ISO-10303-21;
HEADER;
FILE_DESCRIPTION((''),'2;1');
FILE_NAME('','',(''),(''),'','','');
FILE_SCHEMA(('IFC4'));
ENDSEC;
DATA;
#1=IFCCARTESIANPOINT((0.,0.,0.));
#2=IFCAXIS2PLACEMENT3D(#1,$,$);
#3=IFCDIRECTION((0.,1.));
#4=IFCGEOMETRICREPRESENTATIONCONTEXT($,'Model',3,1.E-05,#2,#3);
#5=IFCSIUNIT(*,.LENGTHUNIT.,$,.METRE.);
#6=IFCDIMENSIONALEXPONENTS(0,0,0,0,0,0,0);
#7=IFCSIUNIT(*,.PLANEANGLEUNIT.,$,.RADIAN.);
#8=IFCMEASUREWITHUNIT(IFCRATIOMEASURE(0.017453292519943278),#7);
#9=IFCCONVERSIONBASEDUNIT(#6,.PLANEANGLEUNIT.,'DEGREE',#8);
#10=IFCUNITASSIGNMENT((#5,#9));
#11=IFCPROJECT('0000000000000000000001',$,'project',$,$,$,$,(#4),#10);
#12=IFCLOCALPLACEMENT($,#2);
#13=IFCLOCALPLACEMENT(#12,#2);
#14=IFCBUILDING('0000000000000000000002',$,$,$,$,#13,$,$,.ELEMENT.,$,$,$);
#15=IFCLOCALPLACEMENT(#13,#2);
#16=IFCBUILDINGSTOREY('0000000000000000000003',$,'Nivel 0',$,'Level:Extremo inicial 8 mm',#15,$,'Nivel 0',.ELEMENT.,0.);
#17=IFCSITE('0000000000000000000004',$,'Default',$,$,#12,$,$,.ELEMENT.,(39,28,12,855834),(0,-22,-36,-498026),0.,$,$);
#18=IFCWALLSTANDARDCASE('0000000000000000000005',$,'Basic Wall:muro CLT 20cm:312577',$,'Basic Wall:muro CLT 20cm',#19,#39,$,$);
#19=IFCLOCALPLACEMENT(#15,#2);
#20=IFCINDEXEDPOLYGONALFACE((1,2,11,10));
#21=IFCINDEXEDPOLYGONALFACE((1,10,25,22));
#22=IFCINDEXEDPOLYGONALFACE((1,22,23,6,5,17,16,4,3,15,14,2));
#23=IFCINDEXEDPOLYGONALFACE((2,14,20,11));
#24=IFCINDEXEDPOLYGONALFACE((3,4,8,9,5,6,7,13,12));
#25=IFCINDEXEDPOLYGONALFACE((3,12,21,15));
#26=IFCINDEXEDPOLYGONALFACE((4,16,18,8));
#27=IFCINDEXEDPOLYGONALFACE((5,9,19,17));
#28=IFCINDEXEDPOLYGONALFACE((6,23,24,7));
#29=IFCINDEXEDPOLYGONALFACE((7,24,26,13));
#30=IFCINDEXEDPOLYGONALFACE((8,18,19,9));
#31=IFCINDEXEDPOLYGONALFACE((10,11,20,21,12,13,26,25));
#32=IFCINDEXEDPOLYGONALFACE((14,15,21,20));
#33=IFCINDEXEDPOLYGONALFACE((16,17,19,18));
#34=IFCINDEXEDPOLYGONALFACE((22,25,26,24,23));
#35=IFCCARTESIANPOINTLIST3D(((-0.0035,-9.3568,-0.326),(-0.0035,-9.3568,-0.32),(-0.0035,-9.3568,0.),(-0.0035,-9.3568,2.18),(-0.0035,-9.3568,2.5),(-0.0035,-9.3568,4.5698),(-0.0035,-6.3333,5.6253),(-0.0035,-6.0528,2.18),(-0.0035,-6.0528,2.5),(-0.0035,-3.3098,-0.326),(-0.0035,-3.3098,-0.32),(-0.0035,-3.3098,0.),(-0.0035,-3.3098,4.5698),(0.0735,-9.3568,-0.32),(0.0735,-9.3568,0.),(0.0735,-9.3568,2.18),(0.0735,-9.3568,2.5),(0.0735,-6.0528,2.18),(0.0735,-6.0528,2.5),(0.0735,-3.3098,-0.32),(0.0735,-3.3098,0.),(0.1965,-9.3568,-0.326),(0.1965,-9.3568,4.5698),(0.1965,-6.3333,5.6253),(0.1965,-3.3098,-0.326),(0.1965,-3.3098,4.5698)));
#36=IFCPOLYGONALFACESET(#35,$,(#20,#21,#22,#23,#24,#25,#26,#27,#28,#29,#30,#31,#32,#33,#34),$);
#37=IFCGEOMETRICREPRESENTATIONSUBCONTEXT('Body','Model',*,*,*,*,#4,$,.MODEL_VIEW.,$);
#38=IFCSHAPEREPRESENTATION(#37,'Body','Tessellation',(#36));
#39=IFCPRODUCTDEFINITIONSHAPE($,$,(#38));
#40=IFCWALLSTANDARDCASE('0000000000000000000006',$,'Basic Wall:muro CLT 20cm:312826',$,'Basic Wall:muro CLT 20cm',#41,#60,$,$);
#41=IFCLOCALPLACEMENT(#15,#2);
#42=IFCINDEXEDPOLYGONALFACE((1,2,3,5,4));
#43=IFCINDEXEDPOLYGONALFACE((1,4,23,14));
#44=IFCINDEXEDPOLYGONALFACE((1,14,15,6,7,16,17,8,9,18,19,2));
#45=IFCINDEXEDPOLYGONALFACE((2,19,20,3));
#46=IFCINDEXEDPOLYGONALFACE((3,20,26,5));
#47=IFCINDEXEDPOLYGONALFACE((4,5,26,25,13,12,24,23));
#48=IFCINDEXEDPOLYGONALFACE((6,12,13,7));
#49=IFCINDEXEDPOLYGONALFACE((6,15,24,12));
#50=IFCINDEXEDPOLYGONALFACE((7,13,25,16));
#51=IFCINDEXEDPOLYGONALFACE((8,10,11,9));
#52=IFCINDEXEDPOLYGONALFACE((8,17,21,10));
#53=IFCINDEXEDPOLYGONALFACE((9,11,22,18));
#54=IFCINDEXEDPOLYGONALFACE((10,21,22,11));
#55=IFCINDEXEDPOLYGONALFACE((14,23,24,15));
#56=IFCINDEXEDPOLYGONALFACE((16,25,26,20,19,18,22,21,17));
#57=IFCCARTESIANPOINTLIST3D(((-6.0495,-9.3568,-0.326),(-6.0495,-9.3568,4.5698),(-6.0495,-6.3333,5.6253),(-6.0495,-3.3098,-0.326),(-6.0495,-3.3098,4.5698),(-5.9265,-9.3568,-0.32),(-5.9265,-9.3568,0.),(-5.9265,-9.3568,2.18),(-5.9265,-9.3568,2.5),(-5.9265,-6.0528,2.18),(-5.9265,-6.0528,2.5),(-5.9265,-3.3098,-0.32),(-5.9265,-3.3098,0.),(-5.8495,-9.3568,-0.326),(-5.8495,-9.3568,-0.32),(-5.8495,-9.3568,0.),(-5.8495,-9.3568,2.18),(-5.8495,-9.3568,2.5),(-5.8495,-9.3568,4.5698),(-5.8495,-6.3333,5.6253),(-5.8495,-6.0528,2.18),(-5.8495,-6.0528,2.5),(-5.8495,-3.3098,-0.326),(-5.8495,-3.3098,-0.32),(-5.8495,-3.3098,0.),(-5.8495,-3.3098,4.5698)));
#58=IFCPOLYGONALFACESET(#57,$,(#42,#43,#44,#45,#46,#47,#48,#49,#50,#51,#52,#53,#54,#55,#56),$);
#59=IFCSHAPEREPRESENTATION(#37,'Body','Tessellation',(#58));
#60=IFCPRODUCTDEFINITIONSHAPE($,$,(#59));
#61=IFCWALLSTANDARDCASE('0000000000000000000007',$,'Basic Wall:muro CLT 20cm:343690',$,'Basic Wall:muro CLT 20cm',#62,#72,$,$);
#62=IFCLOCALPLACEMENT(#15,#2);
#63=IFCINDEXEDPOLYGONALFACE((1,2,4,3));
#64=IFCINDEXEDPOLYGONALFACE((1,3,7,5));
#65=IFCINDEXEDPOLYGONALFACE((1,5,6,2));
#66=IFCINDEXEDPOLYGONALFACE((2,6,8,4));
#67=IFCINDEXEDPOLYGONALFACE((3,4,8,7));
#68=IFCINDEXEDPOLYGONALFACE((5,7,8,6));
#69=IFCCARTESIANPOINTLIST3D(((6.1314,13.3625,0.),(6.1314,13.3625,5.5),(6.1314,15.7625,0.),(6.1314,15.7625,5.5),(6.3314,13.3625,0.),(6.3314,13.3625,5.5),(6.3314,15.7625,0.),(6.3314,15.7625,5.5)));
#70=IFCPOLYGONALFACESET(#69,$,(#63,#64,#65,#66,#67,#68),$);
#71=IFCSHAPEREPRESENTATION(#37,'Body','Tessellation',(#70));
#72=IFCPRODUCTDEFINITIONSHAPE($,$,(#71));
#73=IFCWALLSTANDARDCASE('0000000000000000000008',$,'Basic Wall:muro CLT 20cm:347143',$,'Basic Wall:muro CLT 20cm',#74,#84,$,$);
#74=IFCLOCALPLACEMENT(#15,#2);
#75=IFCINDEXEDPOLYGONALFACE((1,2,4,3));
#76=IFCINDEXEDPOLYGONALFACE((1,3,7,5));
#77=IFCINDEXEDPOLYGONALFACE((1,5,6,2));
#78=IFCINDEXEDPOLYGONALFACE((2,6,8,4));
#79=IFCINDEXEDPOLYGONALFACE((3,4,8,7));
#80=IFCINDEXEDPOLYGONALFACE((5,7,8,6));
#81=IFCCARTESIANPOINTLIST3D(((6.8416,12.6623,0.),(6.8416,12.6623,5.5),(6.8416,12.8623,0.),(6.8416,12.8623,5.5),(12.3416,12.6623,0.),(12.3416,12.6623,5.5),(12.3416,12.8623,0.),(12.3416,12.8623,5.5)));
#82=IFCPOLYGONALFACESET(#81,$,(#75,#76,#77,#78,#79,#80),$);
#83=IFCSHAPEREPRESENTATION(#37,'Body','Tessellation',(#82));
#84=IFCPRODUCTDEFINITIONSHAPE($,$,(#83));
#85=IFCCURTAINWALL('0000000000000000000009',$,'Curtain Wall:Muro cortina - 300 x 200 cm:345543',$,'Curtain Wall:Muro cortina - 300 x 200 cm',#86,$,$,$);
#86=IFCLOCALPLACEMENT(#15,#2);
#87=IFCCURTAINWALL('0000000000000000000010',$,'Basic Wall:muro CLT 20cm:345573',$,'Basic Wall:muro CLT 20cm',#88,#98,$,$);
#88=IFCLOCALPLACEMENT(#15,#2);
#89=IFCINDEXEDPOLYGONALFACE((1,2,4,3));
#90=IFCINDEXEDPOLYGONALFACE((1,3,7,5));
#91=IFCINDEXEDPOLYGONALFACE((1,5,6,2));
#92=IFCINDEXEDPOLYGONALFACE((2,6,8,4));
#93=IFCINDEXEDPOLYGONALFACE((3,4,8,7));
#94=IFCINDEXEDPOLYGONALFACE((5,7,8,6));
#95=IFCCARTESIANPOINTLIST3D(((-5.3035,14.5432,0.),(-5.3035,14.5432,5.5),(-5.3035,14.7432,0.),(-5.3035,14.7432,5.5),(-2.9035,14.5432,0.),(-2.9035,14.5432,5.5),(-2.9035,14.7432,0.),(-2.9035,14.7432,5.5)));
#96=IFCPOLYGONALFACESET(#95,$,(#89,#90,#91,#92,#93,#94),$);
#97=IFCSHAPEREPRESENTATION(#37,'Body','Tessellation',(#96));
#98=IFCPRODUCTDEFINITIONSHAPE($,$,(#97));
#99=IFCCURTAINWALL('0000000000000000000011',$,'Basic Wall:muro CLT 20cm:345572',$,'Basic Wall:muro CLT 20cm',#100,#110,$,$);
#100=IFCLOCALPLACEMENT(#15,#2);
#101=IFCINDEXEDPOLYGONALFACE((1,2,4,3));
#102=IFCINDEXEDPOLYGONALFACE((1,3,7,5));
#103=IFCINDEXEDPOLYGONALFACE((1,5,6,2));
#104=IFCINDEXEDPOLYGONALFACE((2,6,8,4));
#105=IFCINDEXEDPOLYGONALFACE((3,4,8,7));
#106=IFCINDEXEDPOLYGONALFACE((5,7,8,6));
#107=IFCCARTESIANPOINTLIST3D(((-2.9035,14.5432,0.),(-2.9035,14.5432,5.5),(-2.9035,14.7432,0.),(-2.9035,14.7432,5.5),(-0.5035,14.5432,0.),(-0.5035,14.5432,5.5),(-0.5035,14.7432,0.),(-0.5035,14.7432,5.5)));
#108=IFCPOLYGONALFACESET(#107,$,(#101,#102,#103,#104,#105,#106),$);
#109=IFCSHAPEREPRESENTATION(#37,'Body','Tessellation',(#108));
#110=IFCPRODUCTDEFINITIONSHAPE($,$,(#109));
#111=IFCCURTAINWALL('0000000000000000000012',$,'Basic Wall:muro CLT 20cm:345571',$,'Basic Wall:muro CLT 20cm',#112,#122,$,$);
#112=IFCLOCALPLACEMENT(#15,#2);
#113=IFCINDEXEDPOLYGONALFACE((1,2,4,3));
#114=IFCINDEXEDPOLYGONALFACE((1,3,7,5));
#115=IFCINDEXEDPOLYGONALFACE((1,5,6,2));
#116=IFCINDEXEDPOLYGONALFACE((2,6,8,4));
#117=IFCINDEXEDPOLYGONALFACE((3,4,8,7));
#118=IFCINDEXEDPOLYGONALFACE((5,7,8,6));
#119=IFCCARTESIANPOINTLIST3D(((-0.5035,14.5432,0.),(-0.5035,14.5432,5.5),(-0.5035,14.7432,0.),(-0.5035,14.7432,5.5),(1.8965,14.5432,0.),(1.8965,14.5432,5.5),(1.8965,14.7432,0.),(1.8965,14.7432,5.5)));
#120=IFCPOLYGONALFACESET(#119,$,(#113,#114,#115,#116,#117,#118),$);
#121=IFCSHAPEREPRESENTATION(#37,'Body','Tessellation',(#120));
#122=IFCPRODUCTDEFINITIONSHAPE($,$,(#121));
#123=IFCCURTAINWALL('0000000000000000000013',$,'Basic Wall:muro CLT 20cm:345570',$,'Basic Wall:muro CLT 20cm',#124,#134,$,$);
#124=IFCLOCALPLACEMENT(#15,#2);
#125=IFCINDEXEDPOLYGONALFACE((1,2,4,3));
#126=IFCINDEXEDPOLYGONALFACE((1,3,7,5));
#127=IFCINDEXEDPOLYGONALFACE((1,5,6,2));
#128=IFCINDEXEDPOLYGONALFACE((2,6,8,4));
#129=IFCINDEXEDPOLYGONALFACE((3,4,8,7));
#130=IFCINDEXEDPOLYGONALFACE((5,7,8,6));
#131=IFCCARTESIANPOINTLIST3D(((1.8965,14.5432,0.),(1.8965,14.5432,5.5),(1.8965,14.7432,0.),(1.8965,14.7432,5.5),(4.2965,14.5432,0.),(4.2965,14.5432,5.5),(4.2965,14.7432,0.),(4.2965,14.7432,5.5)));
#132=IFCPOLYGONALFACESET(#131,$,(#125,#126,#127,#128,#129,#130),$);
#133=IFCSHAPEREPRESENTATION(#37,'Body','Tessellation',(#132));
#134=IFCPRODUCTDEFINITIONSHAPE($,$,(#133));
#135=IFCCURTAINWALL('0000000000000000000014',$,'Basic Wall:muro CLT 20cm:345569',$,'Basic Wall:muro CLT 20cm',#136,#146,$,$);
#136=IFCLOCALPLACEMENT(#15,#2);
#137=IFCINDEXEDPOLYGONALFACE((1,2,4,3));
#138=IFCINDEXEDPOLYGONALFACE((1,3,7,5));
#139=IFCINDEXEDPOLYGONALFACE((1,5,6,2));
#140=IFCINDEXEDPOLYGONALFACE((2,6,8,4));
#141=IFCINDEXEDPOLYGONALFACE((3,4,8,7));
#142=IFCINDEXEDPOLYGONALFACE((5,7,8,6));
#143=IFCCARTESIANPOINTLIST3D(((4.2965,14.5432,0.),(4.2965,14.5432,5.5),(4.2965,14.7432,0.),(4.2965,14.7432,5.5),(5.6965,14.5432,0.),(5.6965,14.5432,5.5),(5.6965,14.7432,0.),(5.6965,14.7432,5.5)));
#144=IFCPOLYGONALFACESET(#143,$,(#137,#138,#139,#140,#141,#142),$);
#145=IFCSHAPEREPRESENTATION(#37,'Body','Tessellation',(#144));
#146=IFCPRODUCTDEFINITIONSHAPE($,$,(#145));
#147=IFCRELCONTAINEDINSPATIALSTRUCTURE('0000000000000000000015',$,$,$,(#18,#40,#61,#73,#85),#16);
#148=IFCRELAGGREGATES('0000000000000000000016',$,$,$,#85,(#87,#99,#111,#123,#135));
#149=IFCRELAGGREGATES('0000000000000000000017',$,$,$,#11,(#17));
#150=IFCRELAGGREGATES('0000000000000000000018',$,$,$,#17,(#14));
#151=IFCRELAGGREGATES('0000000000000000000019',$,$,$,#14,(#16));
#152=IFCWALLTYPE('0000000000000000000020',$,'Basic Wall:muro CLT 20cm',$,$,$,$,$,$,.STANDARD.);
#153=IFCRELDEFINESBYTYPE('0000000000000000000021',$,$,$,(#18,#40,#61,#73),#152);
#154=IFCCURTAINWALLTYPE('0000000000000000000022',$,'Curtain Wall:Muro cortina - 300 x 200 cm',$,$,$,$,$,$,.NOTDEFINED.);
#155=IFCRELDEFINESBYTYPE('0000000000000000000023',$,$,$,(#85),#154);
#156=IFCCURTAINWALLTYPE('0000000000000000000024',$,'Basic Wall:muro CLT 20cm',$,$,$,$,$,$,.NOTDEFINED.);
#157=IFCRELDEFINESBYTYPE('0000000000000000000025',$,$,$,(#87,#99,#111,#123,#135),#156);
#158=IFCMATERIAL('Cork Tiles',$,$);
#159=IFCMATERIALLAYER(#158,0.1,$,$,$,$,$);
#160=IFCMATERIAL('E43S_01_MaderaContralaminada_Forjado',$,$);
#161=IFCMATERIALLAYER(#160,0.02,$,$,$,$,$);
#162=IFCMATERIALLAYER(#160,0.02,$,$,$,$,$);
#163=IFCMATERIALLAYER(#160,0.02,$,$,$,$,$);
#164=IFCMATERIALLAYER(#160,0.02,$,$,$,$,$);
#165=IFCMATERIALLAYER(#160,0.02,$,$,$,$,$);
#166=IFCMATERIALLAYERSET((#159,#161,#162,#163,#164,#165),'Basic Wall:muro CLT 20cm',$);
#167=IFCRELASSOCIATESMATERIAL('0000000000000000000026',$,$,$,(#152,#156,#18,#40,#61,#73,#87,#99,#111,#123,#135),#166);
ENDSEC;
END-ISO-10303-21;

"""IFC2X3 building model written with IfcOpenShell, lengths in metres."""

from ifc_helpers import new_model, entity, si_unit, converted_unit, direction, frame, frame_2d, origin, place, context, subcontext, project, spatial, polyline, rectangle, extrude, clip, bounded_halfspace, material, layer, layer_set, layer_usage, type_object, element, aggregate, save


model = new_model("IFC2X3")

# Units and contexts
model_context = context("Model", 3, precision=1e-05, world=origin(), true_north=direction((0.0, 1.0)))
body_context = subcontext(model_context, "Body", "Model", "MODEL_VIEW")
ifc_project = project(units=[si_unit("LENGTHUNIT", "METRE"), converted_unit("PLANEANGLEUNIT", "DEGREE", entity("IfcRatioMeasure", 0.017453292519943278), si_unit("PLANEANGLEUNIT", "RADIAN"), dimensions=[0, 0, 0, 0, 0, 0, 0])], contexts=[model_context])

# Site, building, storey
site_placement = place(None, origin())
site = spatial("IfcSite", under=ifc_project, at=site_placement, Name="Default", CompositionType="ELEMENT", RefLatitude=(39, 28, 12, 855834), RefLongitude=(0, -22, -36, -498026), RefElevation=0.0)
building_placement = place(site_placement, origin())
building = spatial("IfcBuilding", under=site, at=building_placement, CompositionType="ELEMENT")
storey_placement = place(building_placement, origin())
storey = spatial("IfcBuildingStorey", under=building, at=storey_placement, Name="Nivel 0", ObjectType="Level:Extremo inicial 8 mm", LongName="Nivel 0", CompositionType="ELEMENT", Elevation=0.0)

# Shared definitions
ifc_material_1 = material(Name="E43S_01_MaderaContralaminada_Forjado")
ifc_material_2 = material(Name="Cork Tiles")

# Shared definitions
ifc_layer_1 = layer(ifc_material_2, 0.1)
ifc_layer_2 = layer(ifc_material_1, 0.02)
ifc_layer_3 = layer(ifc_material_1, 0.02)
ifc_layer_4 = layer(ifc_material_1, 0.02)
ifc_layer_5 = layer(ifc_material_1, 0.02)
ifc_layer_6 = layer(ifc_material_1, 0.02)
ifc_layer_set_1 = layer_set([ifc_layer_1, ifc_layer_2, ifc_layer_3, ifc_layer_4, ifc_layer_5, ifc_layer_6], Name="Basic Wall:muro CLT 20cm")
wall_type = type_object("IfcWallType", Name="Basic Wall:muro CLT 20cm", PredefinedType="STANDARD", material=ifc_layer_set_1)

# Walls, openings
ifc_layer_usage_1 = layer_usage(ifc_layer_set_1, "AXIS2", "NEGATIVE", 0.1)
wall_1_placement = place(storey_placement, frame((0.0965, -3.3098, -0.326), z_axis=(0.0, 0.0, 1.0), x_axis=(0.0, -1.0, 0.0)))
wall_1 = element("IfcWallStandardCase", 1, at=wall_1_placement, inside=storey, type_object=wall_type, material=ifc_layer_usage_1, Name="Basic Wall:muro CLT 20cm:312577", ObjectType="Basic Wall:muro CLT 20cm", context=body_context, shape_type="Clipping", body=[
    clip(clip(clip(extrude(rectangle(XDim=6.047, YDim=0.2, at=frame_2d((3.0235, 0.0), x_axis=(-1.0, 0.0))), origin(), (0.0, 0.0, 1.0), 5.9513), bounded_halfspace(frame((0.0, 0.1, 4.8958), z_axis=(-0.329578, 0.0, 0.944128), x_axis=(0.0, -1.0, 0.0)), False, frame((0.0, 0.1, 4.8958)), polyline([(0.0, 0.0), (0.0, -0.2), (3.0235, -0.2), (3.0235, 0.0), (0.0, 0.0)]))), bounded_halfspace(frame((3.0235, -0.1, 5.9513), z_axis=(0.329578, 0.0, 0.944128), x_axis=(0.0, 1.0, 0.0)), False, frame((3.0235, -0.1, 5.9513)), polyline([(0.0, 0.0), (3.0235, 0.0), (3.0235, 0.2), (0.0, 0.2), (0.0, 0.0)]))), bounded_halfspace(frame((6.047, -0.023, 0.006), z_axis=(0.0, 1.0, 0.0), x_axis=(0.0, 0.0, 1.0)), True, frame((6.047, -0.023, 0.006), z_axis=(0.0, 1.0, 0.0), x_axis=(0.0, 0.0, 1.0)), polyline([(0.0, 0.0), (0.0, -6.047), (0.32, -6.047), (0.32, 0.0), (0.0, 0.0)]))),
])
opening_1_placement = place(storey_placement, frame((0.0965, -3.3098, -0.326), z_axis=(0.0, 0.0, 1.0), x_axis=(0.0, -1.0, 0.0)))
element("IfcOpeningElement", 2, at=opening_1_placement, cuts=wall_1, ObjectType="Opening", context=body_context, shape_type="SweptSolid", body=[
    extrude(rectangle(XDim=0.077, YDim=3.304, at=frame_2d((0.0, 0.0), x_axis=(1.0, 0.0))), frame((4.395, -0.0615, 2.506), z_axis=(0.0, 0.0, 1.0), x_axis=(0.0, -1.0, 0.0)), (0.0, 0.0, 1.0), 0.32),
])
ifc_layer_usage_2 = layer_usage(ifc_layer_set_1, "AXIS2", "NEGATIVE", 0.1)
wall_2_placement = place(storey_placement, frame((-5.9495, -9.3568, -0.326), z_axis=(0.0, 0.0, 1.0), x_axis=(0.0, 1.0, 0.0)))
wall_2 = element("IfcWallStandardCase", 3, at=wall_2_placement, inside=storey, type_object=wall_type, material=ifc_layer_usage_2, Name="Basic Wall:muro CLT 20cm:312826", ObjectType="Basic Wall:muro CLT 20cm", context=body_context, shape_type="Clipping", body=[
    clip(clip(clip(extrude(rectangle(XDim=6.047, YDim=0.2, at=frame_2d((3.0235, 0.0), x_axis=(-1.0, 0.0))), origin(), (0.0, 0.0, 1.0), 5.9513), bounded_halfspace(frame((6.047, -0.1, 4.8958), z_axis=(0.329578, 0.0, 0.944128), x_axis=(0.0, 1.0, 0.0)), False, frame((6.047, -0.1, 4.8958)), polyline([(0.0, 0.0), (0.0, 0.2), (-3.0235, 0.2), (-3.0235, 0.0), (0.0, 0.0)]))), bounded_halfspace(frame((0.0, 0.1, 4.8958), z_axis=(-0.329578, 0.0, 0.944128), x_axis=(0.0, -1.0, 0.0)), False, frame((0.0, 0.1, 4.8958)), polyline([(0.0, 0.0), (0.0, -0.2), (3.0235, -0.2), (3.0235, 0.0), (0.0, 0.0)]))), bounded_halfspace(frame((0.0, -0.023, 0.006), z_axis=(0.0, 1.0, 0.0), x_axis=(0.0, 0.0, 1.0)), True, frame((0.0, -0.023, 0.006), z_axis=(0.0, 1.0, 0.0), x_axis=(0.0, 0.0, 1.0)), polyline([(0.0, 0.0), (0.32, 0.0), (0.32, 6.047), (0.0, 6.047), (0.0, 0.0)]))),
])
opening_2_placement = place(storey_placement, frame((-5.9495, -9.3568, -0.326), z_axis=(0.0, 0.0, 1.0), x_axis=(0.0, 1.0, 0.0)))
element("IfcOpeningElement", 4, at=opening_2_placement, cuts=wall_2, ObjectType="Opening", context=body_context, shape_type="SweptSolid", body=[
    extrude(rectangle(XDim=0.077, YDim=3.304, at=frame_2d((0.0, 0.0), x_axis=(1.0, 0.0))), frame((1.652, -0.0615, 2.506), z_axis=(0.0, 0.0, 1.0), x_axis=(0.0, 1.0, 0.0)), (0.0, 0.0, 1.0), 0.32),
])

# Walls
ifc_layer_usage_3 = layer_usage(ifc_layer_set_1, "AXIS2", "NEGATIVE", 0.1)
wall_3_placement = place(storey_placement, frame((6.2314, 13.3625, 0.0), z_axis=(0.0, 0.0, 1.0), x_axis=(0.0, 1.0, 0.0)))
element("IfcWallStandardCase", 5, at=wall_3_placement, inside=storey, type_object=wall_type, material=ifc_layer_usage_3, Name="Basic Wall:muro CLT 20cm:343690", ObjectType="Basic Wall:muro CLT 20cm", context=body_context, shape_type="SweptSolid", body=[
    extrude(rectangle(XDim=2.4, YDim=0.2, at=frame_2d((1.2, 0.0), x_axis=(-1.0, 0.0))), origin(), (0.0, 0.0, 1.0), 5.5),
])
ifc_layer_usage_4 = layer_usage(ifc_layer_set_1, "AXIS2", "POSITIVE", -0.1)
wall_4_placement = place(storey_placement, frame((6.8416, 12.7623, 0.0)))
element("IfcWallStandardCase", 6, at=wall_4_placement, inside=storey, type_object=wall_type, material=ifc_layer_usage_4, Name="Basic Wall:muro CLT 20cm:347143", ObjectType="Basic Wall:muro CLT 20cm", context=body_context, shape_type="SweptSolid", body=[
    extrude(rectangle(XDim=5.5, YDim=0.2, at=frame_2d((2.75, 0.0), x_axis=(-1.0, 0.0))), origin(), (0.0, 0.0, 1.0), 5.5),
])

# Curtain walls
curtain_wall_type_1 = type_object("IfcCurtainWallType", Name="Curtain Wall:Muro cortina - 300 x 200 cm", PredefinedType="NOTDEFINED")
curtain_wall_1_placement = place(storey_placement, origin())
curtain_wall_1 = element("IfcCurtainWall", 7, at=curtain_wall_1_placement, inside=storey, type_object=curtain_wall_type_1, Name="Curtain Wall:Muro cortina - 300 x 200 cm:345543", ObjectType="Curtain Wall:Muro cortina - 300 x 200 cm")
ifc_layer_usage_5 = layer_usage(ifc_layer_set_1, "AXIS2", "NEGATIVE", 0.1)
curtain_wall_type_2 = type_object("IfcCurtainWallType", Name="Basic Wall:muro CLT 20cm", PredefinedType="NOTDEFINED", material=ifc_layer_set_1)
curtain_wall_2_placement = place(storey_placement, frame((-5.3035, 14.6432, 0.0)))
curtain_wall_2 = element("IfcCurtainWall", 8, at=curtain_wall_2_placement, type_object=curtain_wall_type_2, material=ifc_layer_usage_5, Name="Basic Wall:muro CLT 20cm:345573", ObjectType="Basic Wall:muro CLT 20cm", context=body_context, shape_type="SweptSolid", body=[
    extrude(rectangle(XDim=2.4, YDim=0.2, at=frame_2d((1.2, 0.0), x_axis=(-1.0, 0.0))), origin(), (0.0, 0.0, 1.0), 5.5),
])
ifc_layer_usage_6 = layer_usage(ifc_layer_set_1, "AXIS2", "NEGATIVE", 0.1)
curtain_wall_3_placement = place(storey_placement, frame((-2.9035, 14.6432, 0.0)))
curtain_wall_3 = element("IfcCurtainWall", 9, at=curtain_wall_3_placement, type_object=curtain_wall_type_2, material=ifc_layer_usage_6, Name="Basic Wall:muro CLT 20cm:345572", ObjectType="Basic Wall:muro CLT 20cm", context=body_context, shape_type="SweptSolid", body=[
    extrude(rectangle(XDim=2.4, YDim=0.2, at=frame_2d((1.2, 0.0), x_axis=(-1.0, 0.0))), origin(), (0.0, 0.0, 1.0), 5.5),
])
ifc_layer_usage_7 = layer_usage(ifc_layer_set_1, "AXIS2", "NEGATIVE", 0.1)
curtain_wall_4_placement = place(storey_placement, frame((-0.5035, 14.6432, 0.0)))
curtain_wall_4 = element("IfcCurtainWall", 10, at=curtain_wall_4_placement, type_object=curtain_wall_type_2, material=ifc_layer_usage_7, Name="Basic Wall:muro CLT 20cm:345571", ObjectType="Basic Wall:muro CLT 20cm", context=body_context, shape_type="SweptSolid", body=[
    extrude(rectangle(XDim=2.4, YDim=0.2, at=frame_2d((1.2, 0.0), x_axis=(-1.0, 0.0))), origin(), (0.0, 0.0, 1.0), 5.5),
])
ifc_layer_usage_8 = layer_usage(ifc_layer_set_1, "AXIS2", "NEGATIVE", 0.1)
curtain_wall_5_placement = place(storey_placement, frame((1.8965, 14.6432, 0.0)))
curtain_wall_5 = element("IfcCurtainWall", 11, at=curtain_wall_5_placement, type_object=curtain_wall_type_2, material=ifc_layer_usage_8, Name="Basic Wall:muro CLT 20cm:345570", ObjectType="Basic Wall:muro CLT 20cm", context=body_context, shape_type="SweptSolid", body=[
    extrude(rectangle(XDim=2.4, YDim=0.2, at=frame_2d((1.2, 0.0), x_axis=(-1.0, 0.0))), origin(), (0.0, 0.0, 1.0), 5.5),
])
ifc_layer_usage_9 = layer_usage(ifc_layer_set_1, "AXIS2", "NEGATIVE", 0.1)
curtain_wall_6_placement = place(storey_placement, frame((4.2965, 14.6432, 0.0)))
curtain_wall_6 = element("IfcCurtainWall", 12, at=curtain_wall_6_placement, type_object=curtain_wall_type_2, material=ifc_layer_usage_9, Name="Basic Wall:muro CLT 20cm:345569", ObjectType="Basic Wall:muro CLT 20cm", context=body_context, shape_type="SweptSolid", body=[
    extrude(rectangle(XDim=1.4, YDim=0.2, at=frame_2d((0.7, 0.0), x_axis=(-1.0, 0.0))), origin(), (0.0, 0.0, 1.0), 5.5),
])
aggregate(curtain_wall_1, [curtain_wall_2, curtain_wall_3, curtain_wall_4, curtain_wall_5, curtain_wall_6])

save(model, "model.ifc")
